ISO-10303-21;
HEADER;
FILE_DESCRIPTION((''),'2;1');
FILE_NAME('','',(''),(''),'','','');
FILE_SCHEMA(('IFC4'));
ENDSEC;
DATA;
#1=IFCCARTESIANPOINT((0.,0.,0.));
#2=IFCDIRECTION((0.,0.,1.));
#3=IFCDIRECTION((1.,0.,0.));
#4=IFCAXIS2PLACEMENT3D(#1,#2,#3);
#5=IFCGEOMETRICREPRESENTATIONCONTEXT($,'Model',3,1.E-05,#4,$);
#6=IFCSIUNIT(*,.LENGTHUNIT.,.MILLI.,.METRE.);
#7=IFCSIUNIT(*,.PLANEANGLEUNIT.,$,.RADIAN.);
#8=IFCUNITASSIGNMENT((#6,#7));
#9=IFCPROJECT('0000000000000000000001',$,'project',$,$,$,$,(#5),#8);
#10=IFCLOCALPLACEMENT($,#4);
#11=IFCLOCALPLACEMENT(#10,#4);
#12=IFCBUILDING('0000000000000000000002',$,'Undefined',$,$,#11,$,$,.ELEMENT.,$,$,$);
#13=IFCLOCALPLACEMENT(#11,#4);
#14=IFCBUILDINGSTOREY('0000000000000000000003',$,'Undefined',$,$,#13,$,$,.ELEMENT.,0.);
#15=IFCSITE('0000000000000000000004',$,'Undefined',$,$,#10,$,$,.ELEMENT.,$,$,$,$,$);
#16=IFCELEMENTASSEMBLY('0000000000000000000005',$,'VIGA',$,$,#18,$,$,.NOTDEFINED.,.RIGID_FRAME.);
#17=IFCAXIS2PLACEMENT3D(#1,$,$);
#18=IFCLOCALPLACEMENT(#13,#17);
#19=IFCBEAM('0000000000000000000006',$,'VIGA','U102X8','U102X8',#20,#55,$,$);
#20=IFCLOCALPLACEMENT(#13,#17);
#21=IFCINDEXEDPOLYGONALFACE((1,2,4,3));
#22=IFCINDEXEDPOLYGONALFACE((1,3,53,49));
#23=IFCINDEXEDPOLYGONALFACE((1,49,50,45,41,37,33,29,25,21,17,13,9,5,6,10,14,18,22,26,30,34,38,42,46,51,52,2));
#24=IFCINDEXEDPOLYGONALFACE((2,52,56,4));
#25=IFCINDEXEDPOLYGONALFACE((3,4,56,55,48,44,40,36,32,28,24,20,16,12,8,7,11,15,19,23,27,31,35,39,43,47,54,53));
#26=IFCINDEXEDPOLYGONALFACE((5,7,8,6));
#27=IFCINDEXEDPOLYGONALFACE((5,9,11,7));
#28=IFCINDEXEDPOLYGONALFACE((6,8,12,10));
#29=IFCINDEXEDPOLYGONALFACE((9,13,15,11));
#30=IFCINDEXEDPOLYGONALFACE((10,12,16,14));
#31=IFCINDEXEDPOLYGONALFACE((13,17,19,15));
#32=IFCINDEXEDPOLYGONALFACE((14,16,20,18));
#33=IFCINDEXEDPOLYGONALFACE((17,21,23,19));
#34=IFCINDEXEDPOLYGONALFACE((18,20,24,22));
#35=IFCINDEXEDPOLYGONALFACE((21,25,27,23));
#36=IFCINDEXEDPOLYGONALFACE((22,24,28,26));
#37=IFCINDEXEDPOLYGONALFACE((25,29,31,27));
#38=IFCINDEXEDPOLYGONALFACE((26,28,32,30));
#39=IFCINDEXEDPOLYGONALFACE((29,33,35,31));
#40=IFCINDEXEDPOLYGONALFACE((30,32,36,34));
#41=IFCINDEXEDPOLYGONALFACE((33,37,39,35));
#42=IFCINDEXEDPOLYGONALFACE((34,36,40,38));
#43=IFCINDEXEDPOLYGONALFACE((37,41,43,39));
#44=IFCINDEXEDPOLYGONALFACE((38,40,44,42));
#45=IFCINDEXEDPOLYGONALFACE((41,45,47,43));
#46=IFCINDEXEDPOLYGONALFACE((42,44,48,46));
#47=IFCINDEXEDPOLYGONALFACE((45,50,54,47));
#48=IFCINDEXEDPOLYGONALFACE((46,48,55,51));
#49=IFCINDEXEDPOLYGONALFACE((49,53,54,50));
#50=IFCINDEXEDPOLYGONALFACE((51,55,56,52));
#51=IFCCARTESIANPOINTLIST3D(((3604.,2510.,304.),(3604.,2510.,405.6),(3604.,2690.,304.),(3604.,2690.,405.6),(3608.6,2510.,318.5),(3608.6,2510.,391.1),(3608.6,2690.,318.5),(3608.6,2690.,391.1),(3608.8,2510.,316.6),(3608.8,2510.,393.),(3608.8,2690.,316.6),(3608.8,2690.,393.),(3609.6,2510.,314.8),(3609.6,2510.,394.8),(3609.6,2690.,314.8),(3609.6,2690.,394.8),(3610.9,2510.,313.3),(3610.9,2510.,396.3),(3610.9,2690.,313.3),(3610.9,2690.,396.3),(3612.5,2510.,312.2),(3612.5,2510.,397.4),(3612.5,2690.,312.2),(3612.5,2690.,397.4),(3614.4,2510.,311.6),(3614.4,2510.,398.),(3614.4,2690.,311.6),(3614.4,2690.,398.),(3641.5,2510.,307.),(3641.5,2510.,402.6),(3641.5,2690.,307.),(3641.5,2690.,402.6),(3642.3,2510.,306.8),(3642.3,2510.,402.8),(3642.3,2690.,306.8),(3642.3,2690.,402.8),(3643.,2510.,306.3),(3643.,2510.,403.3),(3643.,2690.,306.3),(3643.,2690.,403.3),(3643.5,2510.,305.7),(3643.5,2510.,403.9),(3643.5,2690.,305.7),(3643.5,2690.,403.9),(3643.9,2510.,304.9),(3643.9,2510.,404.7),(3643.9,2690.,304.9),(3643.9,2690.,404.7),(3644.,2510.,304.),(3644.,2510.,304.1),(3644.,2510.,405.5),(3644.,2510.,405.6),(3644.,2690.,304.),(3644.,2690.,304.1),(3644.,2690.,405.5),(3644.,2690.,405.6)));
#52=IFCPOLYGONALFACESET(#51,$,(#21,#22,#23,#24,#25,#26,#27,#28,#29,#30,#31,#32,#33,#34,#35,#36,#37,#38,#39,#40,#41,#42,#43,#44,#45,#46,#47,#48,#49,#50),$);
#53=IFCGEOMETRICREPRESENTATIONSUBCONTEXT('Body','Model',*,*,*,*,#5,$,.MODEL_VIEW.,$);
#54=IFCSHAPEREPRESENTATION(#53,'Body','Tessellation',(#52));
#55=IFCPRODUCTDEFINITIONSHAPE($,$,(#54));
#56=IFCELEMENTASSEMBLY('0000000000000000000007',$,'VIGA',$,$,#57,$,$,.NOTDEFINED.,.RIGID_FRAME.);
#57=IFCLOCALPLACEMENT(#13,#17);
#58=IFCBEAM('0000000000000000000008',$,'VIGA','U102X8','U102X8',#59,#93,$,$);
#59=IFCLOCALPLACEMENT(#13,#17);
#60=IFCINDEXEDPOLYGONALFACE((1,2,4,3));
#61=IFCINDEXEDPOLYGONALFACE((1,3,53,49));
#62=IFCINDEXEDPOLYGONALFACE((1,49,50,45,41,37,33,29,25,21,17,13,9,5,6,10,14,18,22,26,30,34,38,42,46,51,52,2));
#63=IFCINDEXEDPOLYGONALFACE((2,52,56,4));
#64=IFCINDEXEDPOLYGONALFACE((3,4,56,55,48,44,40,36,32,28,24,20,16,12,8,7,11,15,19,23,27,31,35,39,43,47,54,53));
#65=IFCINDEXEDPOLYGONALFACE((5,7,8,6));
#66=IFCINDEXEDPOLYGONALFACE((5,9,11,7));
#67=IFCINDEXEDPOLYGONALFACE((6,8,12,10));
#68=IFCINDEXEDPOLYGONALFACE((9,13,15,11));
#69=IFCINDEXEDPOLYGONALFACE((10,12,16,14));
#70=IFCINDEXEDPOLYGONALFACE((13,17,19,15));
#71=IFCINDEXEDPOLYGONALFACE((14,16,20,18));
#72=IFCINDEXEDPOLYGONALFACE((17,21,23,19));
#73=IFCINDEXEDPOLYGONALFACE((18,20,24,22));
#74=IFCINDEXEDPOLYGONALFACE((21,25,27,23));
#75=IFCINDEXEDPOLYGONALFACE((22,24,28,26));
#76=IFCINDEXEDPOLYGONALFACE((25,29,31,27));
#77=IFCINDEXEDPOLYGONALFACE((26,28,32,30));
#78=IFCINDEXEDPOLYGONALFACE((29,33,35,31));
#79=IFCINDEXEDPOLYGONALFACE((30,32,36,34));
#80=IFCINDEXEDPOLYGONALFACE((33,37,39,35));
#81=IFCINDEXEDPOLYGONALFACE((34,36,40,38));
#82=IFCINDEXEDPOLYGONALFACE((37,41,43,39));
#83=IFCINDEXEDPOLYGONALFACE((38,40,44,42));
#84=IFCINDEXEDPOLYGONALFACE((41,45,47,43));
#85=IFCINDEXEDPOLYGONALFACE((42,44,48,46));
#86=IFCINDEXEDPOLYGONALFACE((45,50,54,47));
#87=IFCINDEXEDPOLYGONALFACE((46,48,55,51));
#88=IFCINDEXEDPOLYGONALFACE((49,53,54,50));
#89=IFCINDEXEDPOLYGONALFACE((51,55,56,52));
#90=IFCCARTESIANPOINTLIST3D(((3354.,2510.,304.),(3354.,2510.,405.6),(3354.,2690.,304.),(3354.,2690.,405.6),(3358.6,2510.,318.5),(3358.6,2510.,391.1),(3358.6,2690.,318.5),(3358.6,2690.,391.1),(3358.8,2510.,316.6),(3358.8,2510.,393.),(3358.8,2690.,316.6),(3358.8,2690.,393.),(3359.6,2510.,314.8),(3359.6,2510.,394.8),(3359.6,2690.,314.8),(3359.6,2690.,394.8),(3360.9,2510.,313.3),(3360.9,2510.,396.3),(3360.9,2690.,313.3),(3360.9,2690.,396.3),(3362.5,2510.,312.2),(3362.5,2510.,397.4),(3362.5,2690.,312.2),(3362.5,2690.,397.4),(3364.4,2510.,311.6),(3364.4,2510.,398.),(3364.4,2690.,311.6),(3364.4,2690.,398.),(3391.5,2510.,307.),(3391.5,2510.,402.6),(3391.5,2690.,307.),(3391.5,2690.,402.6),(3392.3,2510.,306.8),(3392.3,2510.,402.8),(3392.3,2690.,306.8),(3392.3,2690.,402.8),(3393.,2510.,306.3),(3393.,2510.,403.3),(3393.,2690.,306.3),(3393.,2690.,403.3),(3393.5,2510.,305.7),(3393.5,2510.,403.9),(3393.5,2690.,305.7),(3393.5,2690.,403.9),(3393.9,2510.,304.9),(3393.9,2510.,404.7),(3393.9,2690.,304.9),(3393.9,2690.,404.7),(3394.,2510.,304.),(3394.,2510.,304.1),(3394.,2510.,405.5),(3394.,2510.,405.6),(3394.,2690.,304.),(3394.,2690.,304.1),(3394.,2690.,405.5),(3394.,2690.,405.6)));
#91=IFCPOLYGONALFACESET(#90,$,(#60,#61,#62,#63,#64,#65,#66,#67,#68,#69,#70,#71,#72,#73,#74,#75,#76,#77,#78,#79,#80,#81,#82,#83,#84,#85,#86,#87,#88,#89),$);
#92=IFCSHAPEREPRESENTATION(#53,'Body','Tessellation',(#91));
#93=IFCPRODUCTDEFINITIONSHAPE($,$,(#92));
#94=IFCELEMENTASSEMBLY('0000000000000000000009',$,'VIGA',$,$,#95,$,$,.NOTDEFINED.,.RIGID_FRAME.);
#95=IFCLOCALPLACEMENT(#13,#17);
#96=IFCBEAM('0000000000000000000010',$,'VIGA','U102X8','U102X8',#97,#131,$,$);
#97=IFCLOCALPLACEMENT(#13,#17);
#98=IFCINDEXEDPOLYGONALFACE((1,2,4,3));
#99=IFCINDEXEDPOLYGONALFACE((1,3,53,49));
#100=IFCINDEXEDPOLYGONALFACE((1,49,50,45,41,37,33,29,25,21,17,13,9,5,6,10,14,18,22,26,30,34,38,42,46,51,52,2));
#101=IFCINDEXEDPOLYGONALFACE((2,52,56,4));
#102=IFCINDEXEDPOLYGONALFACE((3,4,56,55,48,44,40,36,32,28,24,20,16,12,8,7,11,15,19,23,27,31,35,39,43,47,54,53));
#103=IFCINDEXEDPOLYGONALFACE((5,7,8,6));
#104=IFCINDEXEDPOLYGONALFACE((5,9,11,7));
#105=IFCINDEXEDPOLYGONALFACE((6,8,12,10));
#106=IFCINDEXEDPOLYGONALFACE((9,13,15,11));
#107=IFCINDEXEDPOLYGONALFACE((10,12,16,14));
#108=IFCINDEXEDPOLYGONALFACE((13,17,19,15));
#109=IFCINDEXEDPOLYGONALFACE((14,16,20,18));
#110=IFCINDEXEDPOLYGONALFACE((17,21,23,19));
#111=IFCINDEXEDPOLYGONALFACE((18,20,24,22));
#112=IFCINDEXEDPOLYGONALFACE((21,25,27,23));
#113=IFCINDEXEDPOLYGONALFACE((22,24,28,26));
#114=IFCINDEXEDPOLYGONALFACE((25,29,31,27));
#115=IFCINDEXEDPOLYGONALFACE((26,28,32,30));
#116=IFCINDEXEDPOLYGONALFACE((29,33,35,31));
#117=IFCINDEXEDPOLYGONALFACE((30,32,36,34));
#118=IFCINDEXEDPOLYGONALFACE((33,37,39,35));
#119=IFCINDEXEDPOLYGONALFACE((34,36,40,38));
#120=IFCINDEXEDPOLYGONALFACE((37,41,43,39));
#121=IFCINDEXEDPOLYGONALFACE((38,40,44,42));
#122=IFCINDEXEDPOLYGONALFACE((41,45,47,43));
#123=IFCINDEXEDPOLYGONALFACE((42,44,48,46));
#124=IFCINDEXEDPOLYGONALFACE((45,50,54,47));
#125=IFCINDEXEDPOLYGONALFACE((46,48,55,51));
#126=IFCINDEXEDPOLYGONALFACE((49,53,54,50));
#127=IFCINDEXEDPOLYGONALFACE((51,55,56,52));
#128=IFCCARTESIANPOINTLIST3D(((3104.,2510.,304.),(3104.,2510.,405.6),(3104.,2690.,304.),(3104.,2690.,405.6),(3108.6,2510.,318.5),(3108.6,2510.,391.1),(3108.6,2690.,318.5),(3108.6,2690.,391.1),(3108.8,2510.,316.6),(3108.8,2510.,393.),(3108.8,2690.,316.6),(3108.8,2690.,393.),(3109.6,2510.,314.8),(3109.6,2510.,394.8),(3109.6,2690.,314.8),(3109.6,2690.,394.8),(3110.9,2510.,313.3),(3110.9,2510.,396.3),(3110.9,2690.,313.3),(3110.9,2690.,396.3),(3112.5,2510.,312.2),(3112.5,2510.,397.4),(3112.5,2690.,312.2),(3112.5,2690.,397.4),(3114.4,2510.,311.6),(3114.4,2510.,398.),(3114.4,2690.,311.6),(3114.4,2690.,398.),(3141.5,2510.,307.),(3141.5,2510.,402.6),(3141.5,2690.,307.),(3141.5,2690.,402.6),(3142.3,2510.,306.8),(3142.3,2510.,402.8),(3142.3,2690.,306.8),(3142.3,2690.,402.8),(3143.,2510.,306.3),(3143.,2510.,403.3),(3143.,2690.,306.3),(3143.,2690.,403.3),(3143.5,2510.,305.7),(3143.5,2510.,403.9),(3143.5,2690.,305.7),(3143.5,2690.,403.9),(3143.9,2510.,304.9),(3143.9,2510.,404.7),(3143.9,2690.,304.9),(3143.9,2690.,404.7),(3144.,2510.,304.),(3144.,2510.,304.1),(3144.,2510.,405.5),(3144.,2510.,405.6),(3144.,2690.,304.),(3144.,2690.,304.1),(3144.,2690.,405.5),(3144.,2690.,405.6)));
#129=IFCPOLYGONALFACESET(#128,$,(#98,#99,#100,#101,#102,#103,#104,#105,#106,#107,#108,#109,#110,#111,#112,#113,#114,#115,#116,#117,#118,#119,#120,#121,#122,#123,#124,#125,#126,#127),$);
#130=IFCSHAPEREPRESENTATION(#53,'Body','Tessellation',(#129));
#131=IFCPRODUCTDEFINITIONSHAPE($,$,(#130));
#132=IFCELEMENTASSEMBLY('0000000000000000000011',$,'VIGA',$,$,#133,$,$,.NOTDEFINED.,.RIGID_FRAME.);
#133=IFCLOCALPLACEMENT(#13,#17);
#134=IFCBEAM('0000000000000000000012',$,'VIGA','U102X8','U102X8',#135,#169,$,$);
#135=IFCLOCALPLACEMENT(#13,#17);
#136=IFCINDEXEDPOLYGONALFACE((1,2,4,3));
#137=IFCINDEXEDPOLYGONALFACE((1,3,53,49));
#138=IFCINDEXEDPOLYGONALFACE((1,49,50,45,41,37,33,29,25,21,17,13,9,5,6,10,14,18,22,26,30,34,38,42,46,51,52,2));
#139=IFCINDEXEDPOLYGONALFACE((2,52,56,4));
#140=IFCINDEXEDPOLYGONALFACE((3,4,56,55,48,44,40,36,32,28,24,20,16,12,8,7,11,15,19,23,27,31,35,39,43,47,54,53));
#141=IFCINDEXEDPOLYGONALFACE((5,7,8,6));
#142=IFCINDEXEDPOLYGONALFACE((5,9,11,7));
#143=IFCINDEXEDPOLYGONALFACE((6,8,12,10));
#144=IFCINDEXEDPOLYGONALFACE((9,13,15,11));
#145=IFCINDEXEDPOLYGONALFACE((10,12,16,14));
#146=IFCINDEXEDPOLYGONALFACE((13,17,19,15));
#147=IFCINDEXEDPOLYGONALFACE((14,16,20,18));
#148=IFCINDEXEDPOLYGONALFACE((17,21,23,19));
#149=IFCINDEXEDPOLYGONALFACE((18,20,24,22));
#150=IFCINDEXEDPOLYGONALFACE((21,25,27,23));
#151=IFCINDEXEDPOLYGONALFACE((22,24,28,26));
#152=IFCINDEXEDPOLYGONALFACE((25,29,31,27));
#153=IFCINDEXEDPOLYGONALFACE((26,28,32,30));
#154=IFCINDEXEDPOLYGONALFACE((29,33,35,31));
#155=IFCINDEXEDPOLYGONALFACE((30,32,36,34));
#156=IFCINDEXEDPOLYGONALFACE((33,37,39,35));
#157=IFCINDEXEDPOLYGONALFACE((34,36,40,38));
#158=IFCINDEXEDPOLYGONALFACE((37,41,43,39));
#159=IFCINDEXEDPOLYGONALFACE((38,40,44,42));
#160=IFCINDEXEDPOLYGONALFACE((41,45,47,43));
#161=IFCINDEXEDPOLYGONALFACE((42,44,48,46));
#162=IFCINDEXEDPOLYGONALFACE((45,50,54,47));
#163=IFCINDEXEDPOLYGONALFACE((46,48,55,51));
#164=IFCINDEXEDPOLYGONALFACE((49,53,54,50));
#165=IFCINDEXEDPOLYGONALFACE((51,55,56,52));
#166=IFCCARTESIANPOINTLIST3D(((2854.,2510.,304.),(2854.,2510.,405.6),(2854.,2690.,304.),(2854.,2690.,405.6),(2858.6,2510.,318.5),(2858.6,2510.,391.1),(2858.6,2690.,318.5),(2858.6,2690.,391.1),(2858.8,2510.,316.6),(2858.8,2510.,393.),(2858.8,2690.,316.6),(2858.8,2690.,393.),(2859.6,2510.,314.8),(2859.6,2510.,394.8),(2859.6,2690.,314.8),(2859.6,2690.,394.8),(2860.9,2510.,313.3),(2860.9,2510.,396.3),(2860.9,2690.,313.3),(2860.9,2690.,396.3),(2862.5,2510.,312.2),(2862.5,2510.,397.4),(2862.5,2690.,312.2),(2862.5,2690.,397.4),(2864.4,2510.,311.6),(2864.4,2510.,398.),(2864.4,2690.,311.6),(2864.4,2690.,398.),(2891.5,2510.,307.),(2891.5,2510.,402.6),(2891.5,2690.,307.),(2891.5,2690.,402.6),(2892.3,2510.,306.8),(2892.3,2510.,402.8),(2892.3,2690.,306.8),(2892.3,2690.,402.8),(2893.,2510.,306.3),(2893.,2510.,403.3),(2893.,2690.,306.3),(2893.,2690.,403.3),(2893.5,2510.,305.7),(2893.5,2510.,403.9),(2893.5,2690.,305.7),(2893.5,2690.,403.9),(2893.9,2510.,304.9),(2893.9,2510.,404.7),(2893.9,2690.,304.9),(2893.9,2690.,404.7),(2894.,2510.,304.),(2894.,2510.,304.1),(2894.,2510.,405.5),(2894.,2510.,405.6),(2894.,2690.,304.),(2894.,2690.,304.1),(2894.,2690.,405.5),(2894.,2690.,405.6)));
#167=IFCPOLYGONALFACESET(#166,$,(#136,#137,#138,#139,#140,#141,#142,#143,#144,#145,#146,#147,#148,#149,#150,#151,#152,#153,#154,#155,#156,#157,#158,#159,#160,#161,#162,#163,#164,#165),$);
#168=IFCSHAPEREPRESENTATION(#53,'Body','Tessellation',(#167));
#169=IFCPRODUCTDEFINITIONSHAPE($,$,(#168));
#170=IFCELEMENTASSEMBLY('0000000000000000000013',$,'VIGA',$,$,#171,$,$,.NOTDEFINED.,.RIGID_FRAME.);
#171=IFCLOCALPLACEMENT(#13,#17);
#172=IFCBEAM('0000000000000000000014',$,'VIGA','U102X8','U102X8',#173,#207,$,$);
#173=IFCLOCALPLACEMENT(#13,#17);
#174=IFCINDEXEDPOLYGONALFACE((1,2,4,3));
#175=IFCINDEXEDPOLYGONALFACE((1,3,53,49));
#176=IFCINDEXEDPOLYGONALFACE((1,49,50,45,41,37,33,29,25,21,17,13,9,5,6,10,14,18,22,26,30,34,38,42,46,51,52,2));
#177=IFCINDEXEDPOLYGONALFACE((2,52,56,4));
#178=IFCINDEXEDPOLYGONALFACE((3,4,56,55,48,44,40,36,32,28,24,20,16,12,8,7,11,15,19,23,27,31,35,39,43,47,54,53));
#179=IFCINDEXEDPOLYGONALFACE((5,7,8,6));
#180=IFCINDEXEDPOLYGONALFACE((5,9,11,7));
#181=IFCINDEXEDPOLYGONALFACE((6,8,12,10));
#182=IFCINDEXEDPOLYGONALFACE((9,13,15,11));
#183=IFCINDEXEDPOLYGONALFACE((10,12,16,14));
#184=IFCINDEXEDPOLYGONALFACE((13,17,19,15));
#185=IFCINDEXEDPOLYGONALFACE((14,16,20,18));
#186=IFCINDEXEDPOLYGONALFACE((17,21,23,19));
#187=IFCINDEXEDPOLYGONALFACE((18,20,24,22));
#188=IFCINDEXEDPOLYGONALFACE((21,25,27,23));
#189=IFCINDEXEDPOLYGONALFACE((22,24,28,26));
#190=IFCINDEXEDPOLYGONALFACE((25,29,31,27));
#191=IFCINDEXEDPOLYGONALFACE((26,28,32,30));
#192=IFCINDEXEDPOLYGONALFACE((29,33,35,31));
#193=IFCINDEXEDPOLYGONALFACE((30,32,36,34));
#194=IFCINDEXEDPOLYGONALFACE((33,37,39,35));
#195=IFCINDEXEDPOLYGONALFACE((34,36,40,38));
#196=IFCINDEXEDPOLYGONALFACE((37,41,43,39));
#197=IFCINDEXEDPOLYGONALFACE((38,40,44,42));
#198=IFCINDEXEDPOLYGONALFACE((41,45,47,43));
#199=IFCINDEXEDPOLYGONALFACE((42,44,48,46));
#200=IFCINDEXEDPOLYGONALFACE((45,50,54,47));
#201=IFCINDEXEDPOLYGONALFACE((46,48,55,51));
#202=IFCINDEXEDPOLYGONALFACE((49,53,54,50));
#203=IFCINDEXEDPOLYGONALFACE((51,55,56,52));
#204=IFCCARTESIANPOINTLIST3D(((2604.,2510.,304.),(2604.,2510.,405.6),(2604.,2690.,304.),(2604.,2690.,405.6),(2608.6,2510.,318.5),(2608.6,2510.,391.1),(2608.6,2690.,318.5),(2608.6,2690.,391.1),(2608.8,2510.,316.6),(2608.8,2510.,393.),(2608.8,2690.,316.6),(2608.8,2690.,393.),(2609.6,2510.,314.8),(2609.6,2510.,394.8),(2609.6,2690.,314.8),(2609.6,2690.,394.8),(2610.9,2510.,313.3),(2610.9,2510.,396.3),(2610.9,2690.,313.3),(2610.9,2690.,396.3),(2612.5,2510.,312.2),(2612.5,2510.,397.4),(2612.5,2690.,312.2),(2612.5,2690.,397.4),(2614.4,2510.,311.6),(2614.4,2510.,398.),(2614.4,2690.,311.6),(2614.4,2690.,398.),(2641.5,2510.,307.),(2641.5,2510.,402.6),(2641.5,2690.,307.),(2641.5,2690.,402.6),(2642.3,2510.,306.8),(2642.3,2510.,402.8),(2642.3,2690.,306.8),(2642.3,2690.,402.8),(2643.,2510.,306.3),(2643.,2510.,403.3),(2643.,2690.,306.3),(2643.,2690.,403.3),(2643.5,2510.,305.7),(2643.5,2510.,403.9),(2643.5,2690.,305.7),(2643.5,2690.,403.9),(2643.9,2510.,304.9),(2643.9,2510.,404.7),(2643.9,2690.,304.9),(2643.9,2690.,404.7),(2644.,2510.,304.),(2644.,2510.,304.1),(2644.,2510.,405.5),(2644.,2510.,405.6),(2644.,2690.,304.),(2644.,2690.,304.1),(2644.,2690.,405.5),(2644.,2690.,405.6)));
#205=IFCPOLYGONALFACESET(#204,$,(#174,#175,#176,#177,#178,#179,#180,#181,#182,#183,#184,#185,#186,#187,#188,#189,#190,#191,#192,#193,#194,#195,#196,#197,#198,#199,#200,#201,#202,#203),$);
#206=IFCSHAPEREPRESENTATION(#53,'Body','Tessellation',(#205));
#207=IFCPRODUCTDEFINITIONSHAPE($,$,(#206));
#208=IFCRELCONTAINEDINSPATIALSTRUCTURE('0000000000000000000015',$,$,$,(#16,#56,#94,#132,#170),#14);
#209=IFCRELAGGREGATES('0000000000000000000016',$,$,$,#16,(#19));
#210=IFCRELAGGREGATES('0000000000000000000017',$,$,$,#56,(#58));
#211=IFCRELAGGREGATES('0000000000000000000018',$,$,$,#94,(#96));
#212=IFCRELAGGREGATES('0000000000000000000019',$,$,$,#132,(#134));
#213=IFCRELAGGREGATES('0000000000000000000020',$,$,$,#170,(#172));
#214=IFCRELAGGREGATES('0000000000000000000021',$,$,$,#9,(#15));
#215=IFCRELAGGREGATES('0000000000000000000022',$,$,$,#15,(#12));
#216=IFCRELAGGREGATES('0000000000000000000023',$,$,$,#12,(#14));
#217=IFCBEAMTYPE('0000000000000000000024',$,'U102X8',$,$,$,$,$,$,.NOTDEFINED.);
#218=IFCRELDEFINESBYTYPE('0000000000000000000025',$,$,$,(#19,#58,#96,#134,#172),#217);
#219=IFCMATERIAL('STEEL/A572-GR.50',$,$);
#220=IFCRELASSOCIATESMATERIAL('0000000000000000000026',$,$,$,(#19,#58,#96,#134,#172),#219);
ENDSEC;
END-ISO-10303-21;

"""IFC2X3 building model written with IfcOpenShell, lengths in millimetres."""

from ifc_helpers import new_model, si_unit, frame, origin_with_axes, origin_2d_with_axis, place, context, subcontext, project, spatial, u_section, extrude, material, type_object, element, aggregate, save


model = new_model("IFC2X3")

# Units and contexts
model_context = context("Model", 3, precision=1e-05, world=origin_with_axes())
body_context = subcontext(model_context, "Body", "Model", "MODEL_VIEW")
ifc_project = project(units=[si_unit("LENGTHUNIT", "METRE", prefix="MILLI"), si_unit("PLANEANGLEUNIT", "RADIAN")], contexts=[model_context])

# Site, building, storey
site_placement = place(None, origin_with_axes())
site = spatial("IfcSite", under=ifc_project, at=site_placement, Name="Undefined", CompositionType="ELEMENT")
building_placement = place(site_placement, origin_with_axes())
building = spatial("IfcBuilding", under=site, at=building_placement, Name="Undefined", CompositionType="ELEMENT")
storey_placement = place(building_placement, origin_with_axes())
storey = spatial("IfcBuildingStorey", under=building, at=storey_placement, Name="Undefined", CompositionType="ELEMENT", Elevation=0.0)

# Element assemblies, beams
ifc_material_1 = material(Name="STEEL/A572-GR.50")
beam_type = type_object("IfcBeamType", Name="U102X8", PredefinedType="NOTDEFINED")
assembly_1_placement = place(storey_placement, origin_with_axes())
assembly_1 = element("IfcElementAssembly", 1, at=assembly_1_placement, inside=storey, Name="VIGA", AssemblyPlace="NOTDEFINED", PredefinedType="RIGID_FRAME")
beam_1_placement = place(assembly_1_placement, frame((3624.0, 2510.0, 354.8), z_axis=(0.0, 0.0, 1.0), x_axis=(0.0, 1.0, 0.0)))
beam_1 = element("IfcBeam", 2, at=beam_1_placement, type_object=beam_type, material=ifc_material_1, Name="VIGA", Description="U102X8", ObjectType="U102X8", context=body_context, shape_type="SweptSolid", body=[
    extrude(u_section(Depth=101.6, FlangeWidth=40.0, WebThickness=4.6, FlangeThickness=6.0, FilletRadius=7.0, EdgeRadius=3.0, FlangeSlope=0.16839, at=origin_2d_with_axis()), frame((180.0, 0.0, 0.0), z_axis=(-1.0, 0.0, 0.0), x_axis=(0.0, -1.0, 0.0)), (0.0, 0.0, 1.0), 180.0),
])
aggregate(assembly_1, [beam_1])
assembly_2_placement = place(storey_placement, origin_with_axes())
assembly_2 = element("IfcElementAssembly", 3, at=assembly_2_placement, inside=storey, Name="VIGA", AssemblyPlace="NOTDEFINED", PredefinedType="RIGID_FRAME")
beam_2_placement = place(assembly_2_placement, frame((3374.0, 2510.0, 354.8), z_axis=(0.0, 0.0, 1.0), x_axis=(0.0, 1.0, 0.0)))
beam_2 = element("IfcBeam", 4, at=beam_2_placement, type_object=beam_type, material=ifc_material_1, Name="VIGA", Description="U102X8", ObjectType="U102X8", context=body_context, shape_type="SweptSolid", body=[
    extrude(u_section(Depth=101.6, FlangeWidth=40.0, WebThickness=4.6, FlangeThickness=6.0, FilletRadius=7.0, EdgeRadius=3.0, FlangeSlope=0.16839, at=origin_2d_with_axis()), frame((180.0, 0.0, 0.0), z_axis=(-1.0, 0.0, 0.0), x_axis=(0.0, -1.0, 0.0)), (0.0, 0.0, 1.0), 180.0),
])
aggregate(assembly_2, [beam_2])
assembly_3_placement = place(storey_placement, origin_with_axes())
assembly_3 = element("IfcElementAssembly", 5, at=assembly_3_placement, inside=storey, Name="VIGA", AssemblyPlace="NOTDEFINED", PredefinedType="RIGID_FRAME")
beam_3_placement = place(assembly_3_placement, frame((3124.0, 2510.0, 354.8), z_axis=(0.0, 0.0, 1.0), x_axis=(0.0, 1.0, 0.0)))
beam_3 = element("IfcBeam", 6, at=beam_3_placement, type_object=beam_type, material=ifc_material_1, Name="VIGA", Description="U102X8", ObjectType="U102X8", context=body_context, shape_type="SweptSolid", body=[
    extrude(u_section(Depth=101.6, FlangeWidth=40.0, WebThickness=4.6, FlangeThickness=6.0, FilletRadius=7.0, EdgeRadius=3.0, FlangeSlope=0.16839, at=origin_2d_with_axis()), frame((180.0, 0.0, 0.0), z_axis=(-1.0, 0.0, 0.0), x_axis=(0.0, -1.0, 0.0)), (0.0, 0.0, 1.0), 180.0),
])
aggregate(assembly_3, [beam_3])
assembly_4_placement = place(storey_placement, origin_with_axes())
assembly_4 = element("IfcElementAssembly", 7, at=assembly_4_placement, inside=storey, Name="VIGA", AssemblyPlace="NOTDEFINED", PredefinedType="RIGID_FRAME")
beam_4_placement = place(assembly_4_placement, frame((2874.0, 2510.0, 354.8), z_axis=(0.0, 0.0, 1.0), x_axis=(0.0, 1.0, 0.0)))
beam_4 = element("IfcBeam", 8, at=beam_4_placement, type_object=beam_type, material=ifc_material_1, Name="VIGA", Description="U102X8", ObjectType="U102X8", context=body_context, shape_type="SweptSolid", body=[
    extrude(u_section(Depth=101.6, FlangeWidth=40.0, WebThickness=4.6, FlangeThickness=6.0, FilletRadius=7.0, EdgeRadius=3.0, FlangeSlope=0.16839, at=origin_2d_with_axis()), frame((180.0, 0.0, 0.0), z_axis=(-1.0, 0.0, 0.0), x_axis=(0.0, -1.0, 0.0)), (0.0, 0.0, 1.0), 180.0),
])
aggregate(assembly_4, [beam_4])
assembly_5_placement = place(storey_placement, origin_with_axes())
assembly_5 = element("IfcElementAssembly", 9, at=assembly_5_placement, inside=storey, Name="VIGA", AssemblyPlace="NOTDEFINED", PredefinedType="RIGID_FRAME")
beam_5_placement = place(assembly_5_placement, frame((2624.0, 2510.0, 354.8), z_axis=(0.0, 0.0, 1.0), x_axis=(0.0, 1.0, 0.0)))
beam_5 = element("IfcBeam", 10, at=beam_5_placement, type_object=beam_type, material=ifc_material_1, Name="VIGA", Description="U102X8", ObjectType="U102X8", context=body_context, shape_type="SweptSolid", body=[
    extrude(u_section(Depth=101.6, FlangeWidth=40.0, WebThickness=4.6, FlangeThickness=6.0, FilletRadius=7.0, EdgeRadius=3.0, FlangeSlope=0.16839, at=origin_2d_with_axis()), frame((180.0, 0.0, 0.0), z_axis=(-1.0, 0.0, 0.0), x_axis=(0.0, -1.0, 0.0)), (0.0, 0.0, 1.0), 180.0),
])
aggregate(assembly_5, [beam_5])

save(model, "model.ifc")
